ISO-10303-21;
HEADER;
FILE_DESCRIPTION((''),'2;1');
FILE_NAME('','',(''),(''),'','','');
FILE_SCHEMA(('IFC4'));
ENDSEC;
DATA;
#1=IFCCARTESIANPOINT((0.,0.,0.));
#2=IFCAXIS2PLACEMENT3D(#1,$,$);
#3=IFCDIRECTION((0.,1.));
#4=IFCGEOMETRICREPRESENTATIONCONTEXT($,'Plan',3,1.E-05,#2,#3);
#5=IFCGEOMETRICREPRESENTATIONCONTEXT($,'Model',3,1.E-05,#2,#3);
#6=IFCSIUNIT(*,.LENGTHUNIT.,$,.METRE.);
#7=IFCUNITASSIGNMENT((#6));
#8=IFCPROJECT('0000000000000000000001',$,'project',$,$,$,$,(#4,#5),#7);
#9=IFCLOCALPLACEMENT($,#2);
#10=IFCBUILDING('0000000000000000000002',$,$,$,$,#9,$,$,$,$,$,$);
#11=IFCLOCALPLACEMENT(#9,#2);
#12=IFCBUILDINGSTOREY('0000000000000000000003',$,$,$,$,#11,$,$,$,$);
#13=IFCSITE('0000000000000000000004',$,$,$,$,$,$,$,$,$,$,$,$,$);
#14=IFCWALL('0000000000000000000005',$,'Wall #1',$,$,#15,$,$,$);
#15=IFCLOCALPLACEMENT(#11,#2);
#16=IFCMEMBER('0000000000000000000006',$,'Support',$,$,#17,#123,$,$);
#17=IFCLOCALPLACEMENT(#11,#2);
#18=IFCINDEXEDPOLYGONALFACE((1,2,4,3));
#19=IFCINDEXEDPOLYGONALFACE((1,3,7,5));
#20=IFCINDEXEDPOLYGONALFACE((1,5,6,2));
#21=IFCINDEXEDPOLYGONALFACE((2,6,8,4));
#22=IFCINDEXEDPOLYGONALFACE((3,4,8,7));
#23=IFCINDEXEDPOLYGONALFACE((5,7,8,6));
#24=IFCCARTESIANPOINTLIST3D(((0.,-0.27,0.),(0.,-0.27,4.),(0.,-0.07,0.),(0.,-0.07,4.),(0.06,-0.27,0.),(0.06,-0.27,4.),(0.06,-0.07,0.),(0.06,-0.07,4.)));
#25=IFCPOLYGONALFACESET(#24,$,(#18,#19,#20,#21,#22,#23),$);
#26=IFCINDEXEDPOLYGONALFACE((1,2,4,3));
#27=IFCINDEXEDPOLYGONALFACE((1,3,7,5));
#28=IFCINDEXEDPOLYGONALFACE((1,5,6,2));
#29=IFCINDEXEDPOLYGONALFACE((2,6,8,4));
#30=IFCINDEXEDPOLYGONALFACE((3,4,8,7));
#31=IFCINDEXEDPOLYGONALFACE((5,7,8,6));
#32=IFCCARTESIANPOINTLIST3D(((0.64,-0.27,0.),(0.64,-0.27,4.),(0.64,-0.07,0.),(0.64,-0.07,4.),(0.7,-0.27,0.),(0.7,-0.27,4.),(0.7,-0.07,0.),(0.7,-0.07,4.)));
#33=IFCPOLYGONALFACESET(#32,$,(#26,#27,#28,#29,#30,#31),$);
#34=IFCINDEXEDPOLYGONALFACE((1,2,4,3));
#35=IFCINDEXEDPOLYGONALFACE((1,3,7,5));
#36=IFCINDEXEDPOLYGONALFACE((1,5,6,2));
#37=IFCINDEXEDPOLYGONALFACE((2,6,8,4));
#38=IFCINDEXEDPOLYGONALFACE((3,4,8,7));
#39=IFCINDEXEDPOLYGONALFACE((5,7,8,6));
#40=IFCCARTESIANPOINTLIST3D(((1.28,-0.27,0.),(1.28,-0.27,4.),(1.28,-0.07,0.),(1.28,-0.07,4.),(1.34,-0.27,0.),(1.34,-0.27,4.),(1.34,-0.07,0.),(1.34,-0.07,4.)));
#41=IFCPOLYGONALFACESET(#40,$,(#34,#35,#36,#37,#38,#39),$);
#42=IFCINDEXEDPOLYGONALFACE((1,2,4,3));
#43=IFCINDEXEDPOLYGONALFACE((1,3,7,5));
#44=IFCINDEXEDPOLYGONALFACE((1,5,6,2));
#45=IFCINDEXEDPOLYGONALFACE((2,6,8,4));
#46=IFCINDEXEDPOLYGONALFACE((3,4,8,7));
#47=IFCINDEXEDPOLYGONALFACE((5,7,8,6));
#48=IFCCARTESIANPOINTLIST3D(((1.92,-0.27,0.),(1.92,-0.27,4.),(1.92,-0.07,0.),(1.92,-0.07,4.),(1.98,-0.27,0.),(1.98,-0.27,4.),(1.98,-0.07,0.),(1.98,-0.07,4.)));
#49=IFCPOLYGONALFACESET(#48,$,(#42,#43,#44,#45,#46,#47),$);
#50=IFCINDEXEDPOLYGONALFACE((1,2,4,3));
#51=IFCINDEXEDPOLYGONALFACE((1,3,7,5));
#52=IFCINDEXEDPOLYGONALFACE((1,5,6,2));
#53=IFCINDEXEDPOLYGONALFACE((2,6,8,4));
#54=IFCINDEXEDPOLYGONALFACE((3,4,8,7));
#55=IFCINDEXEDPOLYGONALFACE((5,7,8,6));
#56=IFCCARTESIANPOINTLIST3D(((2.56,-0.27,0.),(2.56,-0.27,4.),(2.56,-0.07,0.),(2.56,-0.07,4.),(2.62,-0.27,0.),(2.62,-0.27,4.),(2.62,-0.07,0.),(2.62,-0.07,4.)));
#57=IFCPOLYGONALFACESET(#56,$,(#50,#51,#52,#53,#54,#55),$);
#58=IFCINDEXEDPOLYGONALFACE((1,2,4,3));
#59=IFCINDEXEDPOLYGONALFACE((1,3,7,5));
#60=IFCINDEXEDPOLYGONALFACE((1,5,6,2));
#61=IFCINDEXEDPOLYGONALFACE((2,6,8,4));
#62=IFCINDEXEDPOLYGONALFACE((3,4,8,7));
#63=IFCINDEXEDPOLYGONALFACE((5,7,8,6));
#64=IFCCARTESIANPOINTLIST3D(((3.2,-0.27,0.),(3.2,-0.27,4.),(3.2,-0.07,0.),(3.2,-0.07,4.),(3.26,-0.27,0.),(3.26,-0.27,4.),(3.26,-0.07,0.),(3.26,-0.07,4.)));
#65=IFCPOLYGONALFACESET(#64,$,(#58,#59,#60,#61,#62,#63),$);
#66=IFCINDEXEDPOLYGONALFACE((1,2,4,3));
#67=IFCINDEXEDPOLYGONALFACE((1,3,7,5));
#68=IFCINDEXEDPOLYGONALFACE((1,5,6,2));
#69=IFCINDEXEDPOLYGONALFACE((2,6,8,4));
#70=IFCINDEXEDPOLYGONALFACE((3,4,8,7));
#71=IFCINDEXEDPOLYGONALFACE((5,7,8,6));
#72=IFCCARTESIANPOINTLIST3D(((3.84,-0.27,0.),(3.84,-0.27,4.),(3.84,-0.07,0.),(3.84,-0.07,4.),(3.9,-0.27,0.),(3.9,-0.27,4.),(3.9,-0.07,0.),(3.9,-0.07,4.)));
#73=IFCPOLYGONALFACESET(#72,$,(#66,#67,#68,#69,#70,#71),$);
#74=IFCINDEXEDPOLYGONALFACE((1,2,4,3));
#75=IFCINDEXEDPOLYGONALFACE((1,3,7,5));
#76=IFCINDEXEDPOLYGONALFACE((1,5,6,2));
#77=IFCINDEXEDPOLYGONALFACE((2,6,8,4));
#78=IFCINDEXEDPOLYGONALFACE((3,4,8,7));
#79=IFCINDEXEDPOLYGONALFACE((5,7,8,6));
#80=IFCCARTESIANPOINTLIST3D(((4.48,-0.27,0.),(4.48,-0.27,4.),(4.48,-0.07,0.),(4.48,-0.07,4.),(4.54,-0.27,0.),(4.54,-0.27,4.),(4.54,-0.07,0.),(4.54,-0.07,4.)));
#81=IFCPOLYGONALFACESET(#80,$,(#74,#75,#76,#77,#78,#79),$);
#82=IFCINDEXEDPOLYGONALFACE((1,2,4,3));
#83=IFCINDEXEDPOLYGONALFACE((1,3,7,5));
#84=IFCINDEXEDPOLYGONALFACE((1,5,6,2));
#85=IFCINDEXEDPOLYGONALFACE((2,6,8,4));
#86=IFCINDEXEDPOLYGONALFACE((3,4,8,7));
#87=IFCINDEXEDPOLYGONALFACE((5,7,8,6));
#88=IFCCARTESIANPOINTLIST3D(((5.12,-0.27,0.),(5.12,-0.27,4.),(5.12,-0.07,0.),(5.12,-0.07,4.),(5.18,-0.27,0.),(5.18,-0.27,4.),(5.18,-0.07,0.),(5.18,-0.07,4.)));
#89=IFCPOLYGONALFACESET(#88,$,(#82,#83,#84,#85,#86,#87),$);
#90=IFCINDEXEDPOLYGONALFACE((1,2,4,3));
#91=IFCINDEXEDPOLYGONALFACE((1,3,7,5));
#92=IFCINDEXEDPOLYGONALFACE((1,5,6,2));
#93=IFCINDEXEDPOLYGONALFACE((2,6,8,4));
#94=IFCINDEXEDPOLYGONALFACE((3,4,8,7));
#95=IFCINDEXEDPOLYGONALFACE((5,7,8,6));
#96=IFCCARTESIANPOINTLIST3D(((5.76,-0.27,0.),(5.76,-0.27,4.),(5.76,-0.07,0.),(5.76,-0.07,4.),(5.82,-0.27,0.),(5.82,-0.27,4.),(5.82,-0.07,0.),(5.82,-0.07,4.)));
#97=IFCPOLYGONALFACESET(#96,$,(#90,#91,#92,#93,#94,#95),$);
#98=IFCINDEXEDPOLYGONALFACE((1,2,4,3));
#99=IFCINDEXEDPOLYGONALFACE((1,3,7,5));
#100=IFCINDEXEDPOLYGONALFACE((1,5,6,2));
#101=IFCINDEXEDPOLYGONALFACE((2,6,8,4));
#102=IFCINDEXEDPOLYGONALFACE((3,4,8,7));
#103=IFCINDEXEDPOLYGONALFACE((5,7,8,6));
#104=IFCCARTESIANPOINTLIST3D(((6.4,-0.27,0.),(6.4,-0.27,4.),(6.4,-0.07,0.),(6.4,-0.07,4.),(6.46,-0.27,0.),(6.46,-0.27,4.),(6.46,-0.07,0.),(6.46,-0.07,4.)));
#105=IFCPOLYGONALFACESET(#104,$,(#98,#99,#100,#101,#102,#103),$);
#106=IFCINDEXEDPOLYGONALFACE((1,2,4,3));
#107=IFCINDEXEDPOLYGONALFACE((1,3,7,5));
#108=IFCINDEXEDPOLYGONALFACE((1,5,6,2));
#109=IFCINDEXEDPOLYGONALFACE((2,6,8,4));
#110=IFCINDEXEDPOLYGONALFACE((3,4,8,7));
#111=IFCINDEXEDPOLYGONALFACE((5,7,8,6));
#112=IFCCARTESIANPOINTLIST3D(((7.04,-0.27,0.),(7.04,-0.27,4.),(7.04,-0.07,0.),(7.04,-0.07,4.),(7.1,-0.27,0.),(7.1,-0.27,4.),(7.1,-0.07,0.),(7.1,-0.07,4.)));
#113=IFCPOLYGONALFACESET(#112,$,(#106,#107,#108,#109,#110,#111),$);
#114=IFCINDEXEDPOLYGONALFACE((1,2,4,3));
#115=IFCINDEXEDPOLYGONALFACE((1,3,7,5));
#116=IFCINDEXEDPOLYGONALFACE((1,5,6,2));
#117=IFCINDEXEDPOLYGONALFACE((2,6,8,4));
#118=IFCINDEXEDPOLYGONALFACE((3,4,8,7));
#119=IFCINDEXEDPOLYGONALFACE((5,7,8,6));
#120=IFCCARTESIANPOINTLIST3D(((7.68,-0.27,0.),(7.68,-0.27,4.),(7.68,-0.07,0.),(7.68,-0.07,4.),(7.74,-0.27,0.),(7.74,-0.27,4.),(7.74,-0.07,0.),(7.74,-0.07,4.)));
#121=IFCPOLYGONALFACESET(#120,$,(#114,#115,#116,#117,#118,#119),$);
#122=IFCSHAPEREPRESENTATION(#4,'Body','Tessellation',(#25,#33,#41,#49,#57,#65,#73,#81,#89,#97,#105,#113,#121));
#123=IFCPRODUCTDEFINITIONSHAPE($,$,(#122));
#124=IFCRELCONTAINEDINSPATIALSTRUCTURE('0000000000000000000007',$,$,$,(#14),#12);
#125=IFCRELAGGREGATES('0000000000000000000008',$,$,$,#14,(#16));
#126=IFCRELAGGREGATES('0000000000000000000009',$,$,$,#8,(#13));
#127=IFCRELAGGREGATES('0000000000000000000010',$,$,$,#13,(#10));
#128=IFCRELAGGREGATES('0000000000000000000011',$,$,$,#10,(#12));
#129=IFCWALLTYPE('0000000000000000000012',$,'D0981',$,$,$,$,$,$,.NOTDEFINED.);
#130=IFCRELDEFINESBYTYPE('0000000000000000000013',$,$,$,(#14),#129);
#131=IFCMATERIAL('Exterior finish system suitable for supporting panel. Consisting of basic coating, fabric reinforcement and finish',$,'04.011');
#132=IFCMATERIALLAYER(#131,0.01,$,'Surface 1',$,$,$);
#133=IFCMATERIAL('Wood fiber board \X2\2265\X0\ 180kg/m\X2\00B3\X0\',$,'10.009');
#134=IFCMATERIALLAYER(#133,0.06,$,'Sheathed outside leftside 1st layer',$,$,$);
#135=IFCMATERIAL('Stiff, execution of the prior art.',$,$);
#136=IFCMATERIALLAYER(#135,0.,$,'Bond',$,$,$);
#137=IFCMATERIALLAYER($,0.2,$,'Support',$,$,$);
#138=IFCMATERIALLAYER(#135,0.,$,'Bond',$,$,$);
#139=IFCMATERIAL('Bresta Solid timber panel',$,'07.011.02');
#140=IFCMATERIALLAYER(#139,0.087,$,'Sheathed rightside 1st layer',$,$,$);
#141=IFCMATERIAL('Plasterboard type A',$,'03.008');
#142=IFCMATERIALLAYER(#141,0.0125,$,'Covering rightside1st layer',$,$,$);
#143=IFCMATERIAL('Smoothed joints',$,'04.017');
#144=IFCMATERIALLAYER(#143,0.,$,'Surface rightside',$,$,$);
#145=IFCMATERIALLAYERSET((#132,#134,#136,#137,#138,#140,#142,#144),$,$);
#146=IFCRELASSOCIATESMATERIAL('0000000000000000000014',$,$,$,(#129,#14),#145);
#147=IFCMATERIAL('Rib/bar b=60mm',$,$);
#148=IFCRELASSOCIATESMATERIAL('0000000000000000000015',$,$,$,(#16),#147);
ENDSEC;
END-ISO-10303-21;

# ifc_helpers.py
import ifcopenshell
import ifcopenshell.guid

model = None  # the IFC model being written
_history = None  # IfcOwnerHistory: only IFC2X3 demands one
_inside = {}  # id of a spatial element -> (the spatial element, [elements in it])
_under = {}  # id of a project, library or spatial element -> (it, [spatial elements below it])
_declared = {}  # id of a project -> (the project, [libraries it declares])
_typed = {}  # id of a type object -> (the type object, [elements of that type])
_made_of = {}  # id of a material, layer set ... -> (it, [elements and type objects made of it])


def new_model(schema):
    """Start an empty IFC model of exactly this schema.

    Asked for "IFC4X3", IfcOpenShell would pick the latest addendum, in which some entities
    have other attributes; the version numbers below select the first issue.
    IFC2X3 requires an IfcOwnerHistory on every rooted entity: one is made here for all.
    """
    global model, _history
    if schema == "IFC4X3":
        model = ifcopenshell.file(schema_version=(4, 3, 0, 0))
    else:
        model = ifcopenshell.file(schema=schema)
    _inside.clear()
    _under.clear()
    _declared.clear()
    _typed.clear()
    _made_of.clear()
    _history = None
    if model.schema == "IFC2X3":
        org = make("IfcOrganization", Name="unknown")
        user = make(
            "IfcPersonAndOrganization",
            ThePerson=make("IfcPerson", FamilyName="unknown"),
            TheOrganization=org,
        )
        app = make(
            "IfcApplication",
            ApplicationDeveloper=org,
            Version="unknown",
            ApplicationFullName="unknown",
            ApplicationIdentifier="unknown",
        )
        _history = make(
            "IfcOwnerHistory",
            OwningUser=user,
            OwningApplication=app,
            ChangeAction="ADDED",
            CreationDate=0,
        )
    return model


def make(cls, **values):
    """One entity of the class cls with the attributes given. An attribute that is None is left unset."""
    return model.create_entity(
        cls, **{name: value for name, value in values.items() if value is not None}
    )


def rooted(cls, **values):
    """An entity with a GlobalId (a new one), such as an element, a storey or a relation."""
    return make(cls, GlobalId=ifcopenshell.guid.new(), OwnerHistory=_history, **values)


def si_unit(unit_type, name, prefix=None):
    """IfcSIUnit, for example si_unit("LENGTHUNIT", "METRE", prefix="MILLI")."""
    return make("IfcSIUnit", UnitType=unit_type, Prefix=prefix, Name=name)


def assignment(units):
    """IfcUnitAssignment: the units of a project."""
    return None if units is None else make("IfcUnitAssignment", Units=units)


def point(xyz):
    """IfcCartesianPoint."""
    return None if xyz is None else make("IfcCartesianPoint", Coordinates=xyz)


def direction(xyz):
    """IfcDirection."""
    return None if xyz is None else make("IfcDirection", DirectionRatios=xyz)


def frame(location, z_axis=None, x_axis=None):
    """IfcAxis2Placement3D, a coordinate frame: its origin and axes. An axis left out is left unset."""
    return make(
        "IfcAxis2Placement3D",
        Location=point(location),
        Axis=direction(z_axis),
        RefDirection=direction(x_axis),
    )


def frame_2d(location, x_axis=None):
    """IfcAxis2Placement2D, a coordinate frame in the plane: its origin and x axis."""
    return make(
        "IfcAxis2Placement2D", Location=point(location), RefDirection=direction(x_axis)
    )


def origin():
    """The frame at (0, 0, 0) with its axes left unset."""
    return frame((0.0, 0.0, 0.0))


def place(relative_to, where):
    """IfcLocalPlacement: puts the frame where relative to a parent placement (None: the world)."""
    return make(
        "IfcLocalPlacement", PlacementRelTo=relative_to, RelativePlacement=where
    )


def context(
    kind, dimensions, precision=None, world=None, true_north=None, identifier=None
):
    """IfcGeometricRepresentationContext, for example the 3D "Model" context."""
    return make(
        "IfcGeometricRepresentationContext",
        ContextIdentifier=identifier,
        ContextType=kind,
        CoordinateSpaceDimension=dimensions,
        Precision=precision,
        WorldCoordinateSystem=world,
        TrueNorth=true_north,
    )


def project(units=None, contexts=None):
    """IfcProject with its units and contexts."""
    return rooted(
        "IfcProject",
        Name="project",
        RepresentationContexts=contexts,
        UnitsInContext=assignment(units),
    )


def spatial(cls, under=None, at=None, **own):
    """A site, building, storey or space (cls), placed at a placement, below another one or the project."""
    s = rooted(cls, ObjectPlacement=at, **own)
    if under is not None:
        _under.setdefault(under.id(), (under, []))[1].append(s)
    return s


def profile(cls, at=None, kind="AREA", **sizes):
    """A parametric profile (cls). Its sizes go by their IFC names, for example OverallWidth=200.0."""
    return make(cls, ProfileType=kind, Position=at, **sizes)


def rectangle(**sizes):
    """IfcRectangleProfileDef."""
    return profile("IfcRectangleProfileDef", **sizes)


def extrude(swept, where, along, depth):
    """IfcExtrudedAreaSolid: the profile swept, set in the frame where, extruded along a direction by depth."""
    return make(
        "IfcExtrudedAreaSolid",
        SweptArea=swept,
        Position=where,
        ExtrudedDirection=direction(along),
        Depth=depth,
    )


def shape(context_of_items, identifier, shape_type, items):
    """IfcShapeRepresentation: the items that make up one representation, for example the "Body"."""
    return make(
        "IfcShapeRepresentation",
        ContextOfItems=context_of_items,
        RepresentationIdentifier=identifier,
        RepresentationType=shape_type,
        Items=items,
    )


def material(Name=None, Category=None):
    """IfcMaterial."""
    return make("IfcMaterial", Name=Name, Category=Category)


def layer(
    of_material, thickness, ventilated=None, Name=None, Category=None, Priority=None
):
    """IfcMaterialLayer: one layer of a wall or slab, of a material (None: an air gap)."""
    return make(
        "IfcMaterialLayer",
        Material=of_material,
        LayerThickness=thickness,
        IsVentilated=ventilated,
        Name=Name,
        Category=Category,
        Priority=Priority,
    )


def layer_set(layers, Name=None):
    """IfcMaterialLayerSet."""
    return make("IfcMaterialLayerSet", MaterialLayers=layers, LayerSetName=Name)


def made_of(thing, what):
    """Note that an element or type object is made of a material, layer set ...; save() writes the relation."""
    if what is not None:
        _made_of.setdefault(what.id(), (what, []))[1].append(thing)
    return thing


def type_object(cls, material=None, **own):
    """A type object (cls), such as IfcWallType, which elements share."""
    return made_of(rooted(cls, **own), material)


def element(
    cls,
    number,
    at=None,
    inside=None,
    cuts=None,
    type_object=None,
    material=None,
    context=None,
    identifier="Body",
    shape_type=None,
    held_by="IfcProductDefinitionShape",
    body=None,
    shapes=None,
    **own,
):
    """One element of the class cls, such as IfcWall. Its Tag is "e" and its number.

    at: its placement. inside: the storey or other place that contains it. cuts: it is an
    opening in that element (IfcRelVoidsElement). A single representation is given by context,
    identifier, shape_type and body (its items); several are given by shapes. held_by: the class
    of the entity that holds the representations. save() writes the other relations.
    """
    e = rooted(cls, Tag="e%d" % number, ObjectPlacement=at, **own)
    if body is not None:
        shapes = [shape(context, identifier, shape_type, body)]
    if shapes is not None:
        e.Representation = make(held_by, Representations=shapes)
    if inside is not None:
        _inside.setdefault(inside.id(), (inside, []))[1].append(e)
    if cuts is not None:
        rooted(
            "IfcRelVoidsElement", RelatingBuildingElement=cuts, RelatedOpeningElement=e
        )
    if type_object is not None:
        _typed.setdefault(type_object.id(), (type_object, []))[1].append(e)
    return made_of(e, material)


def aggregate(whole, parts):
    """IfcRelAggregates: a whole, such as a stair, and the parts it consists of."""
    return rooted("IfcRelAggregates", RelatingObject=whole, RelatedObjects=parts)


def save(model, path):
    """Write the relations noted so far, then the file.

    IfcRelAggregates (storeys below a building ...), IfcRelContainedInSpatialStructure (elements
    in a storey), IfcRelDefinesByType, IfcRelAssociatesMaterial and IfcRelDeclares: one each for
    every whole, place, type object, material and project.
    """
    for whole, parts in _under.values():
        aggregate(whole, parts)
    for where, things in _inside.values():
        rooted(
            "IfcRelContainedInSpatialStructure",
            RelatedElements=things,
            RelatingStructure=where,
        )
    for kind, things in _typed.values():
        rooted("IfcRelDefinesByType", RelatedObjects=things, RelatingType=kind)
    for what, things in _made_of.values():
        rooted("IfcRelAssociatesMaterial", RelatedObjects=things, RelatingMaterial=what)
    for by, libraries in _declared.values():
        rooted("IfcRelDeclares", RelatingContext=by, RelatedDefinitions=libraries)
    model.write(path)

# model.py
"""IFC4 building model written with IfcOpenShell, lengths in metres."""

from ifc_helpers import new_model, si_unit, direction, frame, frame_2d, origin, place, context, project, spatial, rectangle, extrude, material, layer, layer_set, type_object, element, aggregate, save


model = new_model("IFC4")

# Units and contexts
plan_context = context("Plan", 3, precision=1e-05, world=origin(), true_north=direction((0.0, 1.0)))
model_context = context("Model", 3, precision=1e-05, world=origin(), true_north=direction((0.0, 1.0)))
ifc_project = project(units=[si_unit("LENGTHUNIT", "METRE")], contexts=[plan_context, model_context])

# Site, building, storey
site = spatial("IfcSite", under=ifc_project)
building_placement = place(None, origin())
building = spatial("IfcBuilding", under=site, at=building_placement)
storey_placement = place(building_placement, origin())
storey = spatial("IfcBuildingStorey", under=building, at=storey_placement)

# Wall, member
ifc_material_1 = material(Name="Exterior finish system suitable for supporting panel. Consisting of basic coating, fabric reinforcement and finish", Category="04.011")
ifc_layer_1 = layer(ifc_material_1, 0.01, Name="Surface 1")
ifc_material_2 = material(Name="Wood fiber board ≥ 180kg/m³", Category="10.009")
ifc_layer_2 = layer(ifc_material_2, 0.06, Name="Sheathed outside leftside 1st layer")
ifc_material_3 = material(Name="Stiff, execution of the prior art.")
ifc_layer_3 = layer(ifc_material_3, 0.0, Name="Bond")
ifc_layer_4 = layer(None, 0.2, Name="Support")
ifc_layer_5 = layer(ifc_material_3, 0.0, Name="Bond")
ifc_material_4 = material(Name="Bresta Solid timber panel", Category="07.011.02")
ifc_layer_6 = layer(ifc_material_4, 0.087, Name="Sheathed rightside 1st layer")
ifc_material_5 = material(Name="Plasterboard type A", Category="03.008")
ifc_layer_7 = layer(ifc_material_5, 0.0125, Name="Covering rightside1st layer")
ifc_material_6 = material(Name="Smoothed joints", Category="04.017")
ifc_layer_8 = layer(ifc_material_6, 0.0, Name="Surface rightside")
ifc_layer_set = layer_set([ifc_layer_1, ifc_layer_2, ifc_layer_3, ifc_layer_4, ifc_layer_5, ifc_layer_6, ifc_layer_7, ifc_layer_8])
wall_type = type_object("IfcWallType", Name="D0981", PredefinedType="NOTDEFINED", material=ifc_layer_set)
wall_placement = place(None, frame((0.0, 0.0, 0.0), z_axis=(0.0, -1.0, 0.0), x_axis=(1.0, 0.0, 0.0)))
wall = element("IfcWall", 1, at=wall_placement, inside=storey, type_object=wall_type, material=ifc_layer_set, Name="Wall #1")
ifc_material_7 = material(Name="Rib/bar b=60mm")
member_1_placement = place(wall_placement, origin())
member_1 = element("IfcMember", 2, at=member_1_placement, material=ifc_material_7, Name="Support", context=plan_context, shape_type="SweptSolid", body=[
    extrude(rectangle(XDim=0.06, YDim=0.2, at=frame_2d((0.03, 0.1), x_axis=(1.0, 0.0))), frame((0.0, 4.0, 0.07), z_axis=(0.0, -1.0, 0.0), x_axis=(1.0, 0.0, 0.0)), (0.0, 0.0, 1.0), 4.0),
    extrude(rectangle(XDim=0.06, YDim=0.2, at=frame_2d((0.03, 0.1), x_axis=(1.0, 0.0))), frame((0.64, 4.0, 0.07), z_axis=(0.0, -1.0, 0.0), x_axis=(1.0, 0.0, 0.0)), (0.0, 0.0, 1.0), 4.0),
    extrude(rectangle(XDim=0.06, YDim=0.2, at=frame_2d((0.03, 0.1), x_axis=(1.0, 0.0))), frame((1.28, 4.0, 0.07), z_axis=(0.0, -1.0, 0.0), x_axis=(1.0, 0.0, 0.0)), (0.0, 0.0, 1.0), 4.0),
    extrude(rectangle(XDim=0.06, YDim=0.2, at=frame_2d((0.03, 0.1), x_axis=(1.0, 0.0))), frame((1.92, 4.0, 0.07), z_axis=(0.0, -1.0, 0.0), x_axis=(1.0, 0.0, 0.0)), (0.0, 0.0, 1.0), 4.0),
    extrude(rectangle(XDim=0.06, YDim=0.2, at=frame_2d((0.03, 0.1), x_axis=(1.0, 0.0))), frame((2.56, 4.0, 0.07), z_axis=(0.0, -1.0, 0.0), x_axis=(1.0, 0.0, 0.0)), (0.0, 0.0, 1.0), 4.0),
    extrude(rectangle(XDim=0.06, YDim=0.2, at=frame_2d((0.03, 0.1), x_axis=(1.0, 0.0))), frame((3.2, 4.0, 0.07), z_axis=(0.0, -1.0, 0.0), x_axis=(1.0, 0.0, 0.0)), (0.0, 0.0, 1.0), 4.0),
    extrude(rectangle(XDim=0.06, YDim=0.2, at=frame_2d((0.03, 0.1), x_axis=(1.0, 0.0))), frame((3.84, 4.0, 0.07), z_axis=(0.0, -1.0, 0.0), x_axis=(1.0, 0.0, 0.0)), (0.0, 0.0, 1.0), 4.0),
    extrude(rectangle(XDim=0.06, YDim=0.2, at=frame_2d((0.03, 0.1), x_axis=(1.0, 0.0))), frame((4.48, 4.0, 0.07), z_axis=(0.0, -1.0, 0.0), x_axis=(1.0, 0.0, 0.0)), (0.0, 0.0, 1.0), 4.0),
    extrude(rectangle(XDim=0.06, YDim=0.2, at=frame_2d((0.03, 0.1), x_axis=(1.0, 0.0))), frame((5.12, 4.0, 0.07), z_axis=(0.0, -1.0, 0.0), x_axis=(1.0, 0.0, 0.0)), (0.0, 0.0, 1.0), 4.0),
    extrude(rectangle(XDim=0.06, YDim=0.2, at=frame_2d((0.03, 0.1), x_axis=(1.0, 0.0))), frame((5.76, 4.0, 0.07), z_axis=(0.0, -1.0, 0.0), x_axis=(1.0, 0.0, 0.0)), (0.0, 0.0, 1.0), 4.0),
    extrude(rectangle(XDim=0.06, YDim=0.2, at=frame_2d((0.03, 0.1), x_axis=(1.0, 0.0))), frame((6.4, 4.0, 0.07), z_axis=(0.0, -1.0, 0.0), x_axis=(1.0, 0.0, 0.0)), (0.0, 0.0, 1.0), 4.0),
    extrude(rectangle(XDim=0.06, YDim=0.2, at=frame_2d((0.03, 0.1), x_axis=(1.0, 0.0))), frame((7.04, 4.0, 0.07), z_axis=(0.0, -1.0, 0.0), x_axis=(1.0, 0.0, 0.0)), (0.0, 0.0, 1.0), 4.0),
    extrude(rectangle(XDim=0.06, YDim=0.2, at=frame_2d((0.03, 0.1), x_axis=(1.0, 0.0))), frame((7.68, 4.0, 0.07), z_axis=(0.0, -1.0, 0.0), x_axis=(1.0, 0.0, 0.0)), (0.0, 0.0, 1.0), 4.0),
])
aggregate(wall, [member_1])

save(model, "model.ifc")
